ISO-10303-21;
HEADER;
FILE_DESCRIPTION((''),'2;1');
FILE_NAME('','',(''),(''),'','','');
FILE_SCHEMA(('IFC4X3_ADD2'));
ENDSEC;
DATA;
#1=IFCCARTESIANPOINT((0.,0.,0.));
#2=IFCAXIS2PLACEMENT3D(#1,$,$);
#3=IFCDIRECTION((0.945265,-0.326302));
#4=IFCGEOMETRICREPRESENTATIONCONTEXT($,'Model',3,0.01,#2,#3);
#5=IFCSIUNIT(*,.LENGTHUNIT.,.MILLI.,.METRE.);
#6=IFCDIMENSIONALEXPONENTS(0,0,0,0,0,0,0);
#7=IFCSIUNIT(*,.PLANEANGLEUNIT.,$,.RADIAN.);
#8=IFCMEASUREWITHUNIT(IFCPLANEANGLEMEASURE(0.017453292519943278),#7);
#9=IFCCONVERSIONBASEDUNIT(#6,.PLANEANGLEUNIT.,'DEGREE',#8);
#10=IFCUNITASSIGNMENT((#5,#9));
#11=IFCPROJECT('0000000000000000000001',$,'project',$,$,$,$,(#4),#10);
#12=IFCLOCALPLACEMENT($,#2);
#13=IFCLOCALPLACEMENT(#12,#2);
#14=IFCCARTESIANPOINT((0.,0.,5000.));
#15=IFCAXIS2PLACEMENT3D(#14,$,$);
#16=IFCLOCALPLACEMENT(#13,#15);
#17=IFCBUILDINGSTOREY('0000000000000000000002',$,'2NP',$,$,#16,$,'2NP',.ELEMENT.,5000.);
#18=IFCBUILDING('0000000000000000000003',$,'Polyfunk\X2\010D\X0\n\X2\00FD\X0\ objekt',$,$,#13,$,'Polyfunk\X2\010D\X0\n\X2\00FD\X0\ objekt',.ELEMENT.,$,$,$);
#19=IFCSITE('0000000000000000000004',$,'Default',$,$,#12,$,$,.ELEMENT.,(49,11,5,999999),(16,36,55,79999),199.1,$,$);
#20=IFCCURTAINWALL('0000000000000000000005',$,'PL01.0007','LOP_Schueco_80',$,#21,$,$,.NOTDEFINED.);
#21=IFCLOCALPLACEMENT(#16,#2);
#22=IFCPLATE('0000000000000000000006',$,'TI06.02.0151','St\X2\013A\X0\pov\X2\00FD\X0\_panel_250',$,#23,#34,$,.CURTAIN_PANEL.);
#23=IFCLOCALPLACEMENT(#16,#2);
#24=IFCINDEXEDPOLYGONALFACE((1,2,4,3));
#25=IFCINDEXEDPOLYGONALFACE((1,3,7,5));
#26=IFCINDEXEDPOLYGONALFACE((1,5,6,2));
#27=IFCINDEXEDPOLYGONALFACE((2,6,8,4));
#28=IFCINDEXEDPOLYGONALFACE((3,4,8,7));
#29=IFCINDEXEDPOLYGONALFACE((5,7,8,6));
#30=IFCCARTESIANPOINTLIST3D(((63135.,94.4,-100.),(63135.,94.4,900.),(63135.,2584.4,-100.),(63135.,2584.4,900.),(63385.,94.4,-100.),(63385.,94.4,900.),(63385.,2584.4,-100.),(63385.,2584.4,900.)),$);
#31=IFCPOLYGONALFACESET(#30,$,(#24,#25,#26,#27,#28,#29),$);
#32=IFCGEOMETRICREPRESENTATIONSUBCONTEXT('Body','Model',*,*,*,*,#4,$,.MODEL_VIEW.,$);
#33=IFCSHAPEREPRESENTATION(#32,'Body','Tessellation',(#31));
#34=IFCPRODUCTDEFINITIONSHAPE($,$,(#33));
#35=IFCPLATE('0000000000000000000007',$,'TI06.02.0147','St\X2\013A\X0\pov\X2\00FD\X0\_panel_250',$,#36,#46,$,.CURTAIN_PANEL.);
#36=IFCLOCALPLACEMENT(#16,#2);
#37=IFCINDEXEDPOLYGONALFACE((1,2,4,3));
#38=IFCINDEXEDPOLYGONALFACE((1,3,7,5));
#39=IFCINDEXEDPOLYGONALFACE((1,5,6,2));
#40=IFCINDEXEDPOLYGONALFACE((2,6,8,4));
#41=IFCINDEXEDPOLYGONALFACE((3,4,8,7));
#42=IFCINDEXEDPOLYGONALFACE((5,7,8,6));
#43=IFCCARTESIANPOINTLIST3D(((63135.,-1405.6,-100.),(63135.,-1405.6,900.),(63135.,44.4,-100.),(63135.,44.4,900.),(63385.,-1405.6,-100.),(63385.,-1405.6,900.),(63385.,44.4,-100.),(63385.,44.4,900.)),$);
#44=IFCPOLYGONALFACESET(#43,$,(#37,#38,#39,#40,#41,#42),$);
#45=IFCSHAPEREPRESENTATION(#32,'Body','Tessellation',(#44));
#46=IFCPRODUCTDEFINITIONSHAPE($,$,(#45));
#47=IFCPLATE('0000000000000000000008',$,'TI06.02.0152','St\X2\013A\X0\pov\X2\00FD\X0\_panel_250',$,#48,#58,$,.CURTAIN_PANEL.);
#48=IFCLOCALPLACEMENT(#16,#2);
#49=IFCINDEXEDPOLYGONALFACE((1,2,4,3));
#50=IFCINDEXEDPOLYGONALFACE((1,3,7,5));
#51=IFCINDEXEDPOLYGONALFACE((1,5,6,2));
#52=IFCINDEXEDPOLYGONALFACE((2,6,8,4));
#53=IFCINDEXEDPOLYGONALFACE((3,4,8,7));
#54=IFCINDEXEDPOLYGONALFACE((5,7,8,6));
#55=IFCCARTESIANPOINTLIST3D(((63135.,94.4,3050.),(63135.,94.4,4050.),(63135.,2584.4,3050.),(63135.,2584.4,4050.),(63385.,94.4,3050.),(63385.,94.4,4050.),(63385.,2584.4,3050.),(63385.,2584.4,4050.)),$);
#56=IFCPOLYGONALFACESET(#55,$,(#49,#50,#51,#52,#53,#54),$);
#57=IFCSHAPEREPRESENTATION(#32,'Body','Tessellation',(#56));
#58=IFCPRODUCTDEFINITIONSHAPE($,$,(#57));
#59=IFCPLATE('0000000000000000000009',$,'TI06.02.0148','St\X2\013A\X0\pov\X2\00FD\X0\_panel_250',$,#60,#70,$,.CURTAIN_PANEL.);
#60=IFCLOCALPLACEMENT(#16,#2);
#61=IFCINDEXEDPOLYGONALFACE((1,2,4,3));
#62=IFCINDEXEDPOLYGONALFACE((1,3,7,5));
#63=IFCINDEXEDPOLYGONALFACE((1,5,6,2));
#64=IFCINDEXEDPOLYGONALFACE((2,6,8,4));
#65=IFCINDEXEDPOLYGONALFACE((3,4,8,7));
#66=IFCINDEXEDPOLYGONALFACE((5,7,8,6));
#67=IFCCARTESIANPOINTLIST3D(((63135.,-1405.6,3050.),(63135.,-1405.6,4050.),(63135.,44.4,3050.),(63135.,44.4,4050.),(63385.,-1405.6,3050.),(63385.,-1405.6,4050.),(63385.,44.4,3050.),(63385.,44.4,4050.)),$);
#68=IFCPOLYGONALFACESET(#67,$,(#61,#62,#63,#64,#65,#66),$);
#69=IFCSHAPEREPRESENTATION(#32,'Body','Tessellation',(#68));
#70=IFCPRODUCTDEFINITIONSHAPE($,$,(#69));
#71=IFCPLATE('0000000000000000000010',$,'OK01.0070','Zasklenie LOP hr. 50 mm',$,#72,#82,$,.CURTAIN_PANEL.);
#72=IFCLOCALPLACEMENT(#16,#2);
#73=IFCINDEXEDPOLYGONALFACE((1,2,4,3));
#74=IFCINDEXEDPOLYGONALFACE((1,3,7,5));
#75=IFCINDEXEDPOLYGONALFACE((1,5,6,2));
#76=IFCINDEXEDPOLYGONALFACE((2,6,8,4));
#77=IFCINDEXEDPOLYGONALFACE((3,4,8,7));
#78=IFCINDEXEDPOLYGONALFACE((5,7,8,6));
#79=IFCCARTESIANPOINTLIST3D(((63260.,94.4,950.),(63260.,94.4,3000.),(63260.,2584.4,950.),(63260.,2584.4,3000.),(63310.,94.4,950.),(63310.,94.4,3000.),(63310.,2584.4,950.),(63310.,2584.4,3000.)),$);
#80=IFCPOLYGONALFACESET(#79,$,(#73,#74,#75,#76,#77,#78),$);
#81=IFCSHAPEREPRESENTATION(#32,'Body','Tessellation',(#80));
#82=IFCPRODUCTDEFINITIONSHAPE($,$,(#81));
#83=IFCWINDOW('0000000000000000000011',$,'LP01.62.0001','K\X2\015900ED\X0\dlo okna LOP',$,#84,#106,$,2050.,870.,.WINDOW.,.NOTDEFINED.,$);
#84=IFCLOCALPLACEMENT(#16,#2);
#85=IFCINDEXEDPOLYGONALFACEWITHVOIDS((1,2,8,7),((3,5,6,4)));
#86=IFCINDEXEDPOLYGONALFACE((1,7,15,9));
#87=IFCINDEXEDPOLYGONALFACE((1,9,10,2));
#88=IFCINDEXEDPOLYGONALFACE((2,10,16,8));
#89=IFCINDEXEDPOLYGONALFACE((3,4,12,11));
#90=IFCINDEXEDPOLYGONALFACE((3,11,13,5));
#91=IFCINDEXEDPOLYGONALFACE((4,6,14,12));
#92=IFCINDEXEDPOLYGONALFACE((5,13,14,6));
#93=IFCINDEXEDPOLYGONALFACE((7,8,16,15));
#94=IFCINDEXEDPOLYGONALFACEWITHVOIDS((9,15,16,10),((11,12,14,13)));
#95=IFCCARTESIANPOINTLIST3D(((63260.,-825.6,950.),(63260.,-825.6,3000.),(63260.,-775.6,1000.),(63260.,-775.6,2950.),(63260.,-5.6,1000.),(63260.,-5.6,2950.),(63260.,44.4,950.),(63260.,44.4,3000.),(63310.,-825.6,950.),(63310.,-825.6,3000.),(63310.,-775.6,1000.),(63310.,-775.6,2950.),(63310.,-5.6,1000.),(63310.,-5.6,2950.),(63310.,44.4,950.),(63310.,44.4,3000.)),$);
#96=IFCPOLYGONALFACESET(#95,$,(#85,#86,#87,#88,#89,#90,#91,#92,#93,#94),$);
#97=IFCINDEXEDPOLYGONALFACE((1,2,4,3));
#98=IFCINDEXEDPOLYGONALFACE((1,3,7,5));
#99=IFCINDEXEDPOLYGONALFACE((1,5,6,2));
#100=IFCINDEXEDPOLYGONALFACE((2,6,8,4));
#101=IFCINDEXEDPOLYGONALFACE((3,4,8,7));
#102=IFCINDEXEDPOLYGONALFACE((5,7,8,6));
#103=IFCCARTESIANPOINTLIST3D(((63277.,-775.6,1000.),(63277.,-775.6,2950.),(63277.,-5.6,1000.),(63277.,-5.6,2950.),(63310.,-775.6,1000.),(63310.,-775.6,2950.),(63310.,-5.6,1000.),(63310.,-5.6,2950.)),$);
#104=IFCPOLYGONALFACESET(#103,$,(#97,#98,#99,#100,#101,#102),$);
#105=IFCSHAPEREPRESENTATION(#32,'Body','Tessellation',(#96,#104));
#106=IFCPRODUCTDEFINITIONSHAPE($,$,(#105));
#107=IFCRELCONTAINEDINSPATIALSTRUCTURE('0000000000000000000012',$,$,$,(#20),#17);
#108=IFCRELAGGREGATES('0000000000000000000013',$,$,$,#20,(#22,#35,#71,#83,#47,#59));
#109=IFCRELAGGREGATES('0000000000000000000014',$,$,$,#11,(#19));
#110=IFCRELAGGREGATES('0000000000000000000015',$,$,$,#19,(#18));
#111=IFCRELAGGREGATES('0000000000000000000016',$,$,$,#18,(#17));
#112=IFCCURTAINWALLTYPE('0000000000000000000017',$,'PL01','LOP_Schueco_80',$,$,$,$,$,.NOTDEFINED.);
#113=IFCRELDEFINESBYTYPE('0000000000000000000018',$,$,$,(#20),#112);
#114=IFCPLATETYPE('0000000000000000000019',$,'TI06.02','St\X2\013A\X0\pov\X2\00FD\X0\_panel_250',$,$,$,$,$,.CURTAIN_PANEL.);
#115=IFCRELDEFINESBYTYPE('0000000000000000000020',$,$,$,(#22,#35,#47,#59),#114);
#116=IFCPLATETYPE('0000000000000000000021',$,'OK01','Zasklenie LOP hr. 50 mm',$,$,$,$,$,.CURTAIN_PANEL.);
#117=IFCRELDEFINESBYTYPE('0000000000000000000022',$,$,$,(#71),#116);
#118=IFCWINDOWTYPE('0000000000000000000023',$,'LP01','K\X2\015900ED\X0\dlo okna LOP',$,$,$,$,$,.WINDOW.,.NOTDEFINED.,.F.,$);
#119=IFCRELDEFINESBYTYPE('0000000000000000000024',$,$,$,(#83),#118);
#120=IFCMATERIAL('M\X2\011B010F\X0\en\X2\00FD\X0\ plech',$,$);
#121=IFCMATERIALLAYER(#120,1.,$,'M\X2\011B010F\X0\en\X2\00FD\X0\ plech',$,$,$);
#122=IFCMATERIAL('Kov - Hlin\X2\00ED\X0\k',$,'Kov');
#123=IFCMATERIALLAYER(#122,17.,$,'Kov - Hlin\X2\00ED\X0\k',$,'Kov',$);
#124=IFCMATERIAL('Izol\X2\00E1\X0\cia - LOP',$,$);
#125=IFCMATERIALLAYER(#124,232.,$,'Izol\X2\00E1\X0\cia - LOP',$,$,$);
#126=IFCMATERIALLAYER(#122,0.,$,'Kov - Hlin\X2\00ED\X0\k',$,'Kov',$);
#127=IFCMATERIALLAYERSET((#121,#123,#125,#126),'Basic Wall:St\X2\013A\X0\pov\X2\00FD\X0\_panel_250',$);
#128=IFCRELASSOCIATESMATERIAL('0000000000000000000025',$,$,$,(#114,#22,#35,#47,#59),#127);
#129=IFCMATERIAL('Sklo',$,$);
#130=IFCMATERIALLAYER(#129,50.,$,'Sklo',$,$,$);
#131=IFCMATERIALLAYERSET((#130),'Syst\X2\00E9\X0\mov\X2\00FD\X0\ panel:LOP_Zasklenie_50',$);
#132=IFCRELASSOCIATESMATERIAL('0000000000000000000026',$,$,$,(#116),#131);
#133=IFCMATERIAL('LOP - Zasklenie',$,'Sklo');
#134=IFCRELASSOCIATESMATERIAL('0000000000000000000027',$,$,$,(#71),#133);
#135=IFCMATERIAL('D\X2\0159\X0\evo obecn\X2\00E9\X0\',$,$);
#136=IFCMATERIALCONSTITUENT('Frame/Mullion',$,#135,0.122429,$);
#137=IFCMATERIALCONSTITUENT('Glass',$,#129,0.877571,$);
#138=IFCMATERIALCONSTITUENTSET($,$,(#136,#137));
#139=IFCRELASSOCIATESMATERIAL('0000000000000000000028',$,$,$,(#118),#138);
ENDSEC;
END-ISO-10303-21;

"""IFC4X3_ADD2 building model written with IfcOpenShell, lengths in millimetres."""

from ifc_helpers import new_model, entity, si_unit, converted_unit, direction, frame, frame_2d, origin, origin_2d_with_axis, place, context, subcontext, project, spatial, polyline, rectangle, outline, extrude, source, transform, mapped, material, layer, layer_set, layer_usage, constituent, constituent_set, type_object, type_shapes, element, aggregate, save


model = new_model("IFC4X3_ADD2")

# Units and contexts
model_context = context("Model", 3, precision=0.01, world=origin(), true_north=direction((0.945265, -0.326302)))
body_context = subcontext(model_context, "Body", "Model", "MODEL_VIEW")
ifc_project = project(units=[si_unit("LENGTHUNIT", "METRE", prefix="MILLI"), converted_unit("PLANEANGLEUNIT", "DEGREE", entity("IfcPlaneAngleMeasure", 0.017453292519943278), si_unit("PLANEANGLEUNIT", "RADIAN"), dimensions=[0, 0, 0, 0, 0, 0, 0])], contexts=[model_context])

# Site, building, storey
site_placement = place(None, origin())
site = spatial("IfcSite", under=ifc_project, at=site_placement, Name="Default", CompositionType="ELEMENT", RefLatitude=(49, 11, 5, 999999), RefLongitude=(16, 36, 55, 79999), RefElevation=199.1)
building_placement = place(site_placement, origin())
building = spatial("IfcBuilding", under=site, at=building_placement, Name="Polyfunkčný objekt", LongName="Polyfunkčný objekt", CompositionType="ELEMENT")
storey_placement = place(building_placement, frame((0.0, 0.0, 5000.0)))
storey = spatial("IfcBuildingStorey", under=building, at=storey_placement, Name="2NP", LongName="2NP", CompositionType="ELEMENT", Elevation=5000.0)

# Curtain wall, plates, window
curtain_wall_type = type_object("IfcCurtainWallType", Name="PL01", Description="LOP_Schueco_80", PredefinedType="NOTDEFINED")
curtain_wall_placement = place(storey_placement, frame((0.0, 0.0, -5000.0)))
curtain_wall = element("IfcCurtainWall", 1, at=curtain_wall_placement, inside=storey, type_object=curtain_wall_type, Name="PL01.0007", Description="LOP_Schueco_80", PredefinedType="NOTDEFINED")
ifc_material_1 = material(Name="Měďený plech")
ifc_layer_1 = layer(ifc_material_1, 1.0, Name="Měďený plech")
ifc_material_2 = material(Name="Kov - Hliník", Category="Kov")
ifc_layer_2 = layer(ifc_material_2, 17.0, Name="Kov - Hliník", Category="Kov")
ifc_material_3 = material(Name="Izolácia - LOP")
ifc_layer_3 = layer(ifc_material_3, 232.0, Name="Izolácia - LOP")
ifc_layer_4 = layer(ifc_material_2, 0.0, Name="Kov - Hliník", Category="Kov")
ifc_layer_set_1 = layer_set([ifc_layer_1, ifc_layer_2, ifc_layer_3, ifc_layer_4], Name="Basic Wall:Stĺpový_panel_250")
ifc_layer_usage_1 = layer_usage(ifc_layer_set_1, "AXIS2", "NEGATIVE", 125.0)
plate_type_1 = type_object("IfcPlateType", Name="TI06.02", Description="Stĺpový_panel_250", PredefinedType="CURTAIN_PANEL", material=ifc_layer_set_1)
plate_1_placement = place(storey_placement, frame((63260.0, 2584.4, -100.0), z_axis=(0.0, 0.0, 1.0), x_axis=(0.0, -1.0, 0.0)))
plate_1 = element("IfcPlate", 2, at=plate_1_placement, type_object=plate_type_1, material=ifc_layer_usage_1, Name="TI06.02.0151", Description="Stĺpový_panel_250", PredefinedType="CURTAIN_PANEL", context=body_context, shape_type="SweptSolid", body=[
    extrude(rectangle(XDim=250.0, YDim=2490.0, at=frame_2d((0.0, 0.0), x_axis=(1.0, 0.0))), frame((1245.0, 0.0, 0.0), z_axis=(0.0, 0.0, 1.0), x_axis=(0.0, 1.0, 0.0)), (0.0, 0.0, 1.0), 1000.0),
])
ifc_layer_usage_2 = layer_usage(ifc_layer_set_1, "AXIS2", "NEGATIVE", 125.0)
plate_2_placement = place(storey_placement, frame((63260.0, 44.4, -100.0), z_axis=(0.0, 0.0, 1.0), x_axis=(0.0, -1.0, 0.0)))
plate_2 = element("IfcPlate", 3, at=plate_2_placement, type_object=plate_type_1, material=ifc_layer_usage_2, Name="TI06.02.0147", Description="Stĺpový_panel_250", PredefinedType="CURTAIN_PANEL", context=body_context, shape_type="SweptSolid", body=[
    extrude(rectangle(XDim=250.0, YDim=1450.0, at=frame_2d((0.0, 0.0), x_axis=(1.0, 0.0))), frame((725.0, 0.0, 0.0), z_axis=(0.0, 0.0, 1.0), x_axis=(0.0, 1.0, 0.0)), (0.0, 0.0, 1.0), 1000.0),
])
ifc_layer_usage_3 = layer_usage(ifc_layer_set_1, "AXIS2", "NEGATIVE", 125.0)
plate_3_placement = place(storey_placement, frame((63260.0, 2584.4, 3050.0), z_axis=(0.0, 0.0, 1.0), x_axis=(0.0, -1.0, 0.0)))
plate_3 = element("IfcPlate", 4, at=plate_3_placement, type_object=plate_type_1, material=ifc_layer_usage_3, Name="TI06.02.0152", Description="Stĺpový_panel_250", PredefinedType="CURTAIN_PANEL", context=body_context, shape_type="SweptSolid", body=[
    extrude(rectangle(XDim=250.0, YDim=2490.0, at=frame_2d((0.0, 0.0), x_axis=(1.0, 0.0))), frame((1245.0, 0.0, 0.0), z_axis=(0.0, 0.0, 1.0), x_axis=(0.0, 1.0, 0.0)), (0.0, 0.0, 1.0), 1000.0),
])
ifc_layer_usage_4 = layer_usage(ifc_layer_set_1, "AXIS2", "NEGATIVE", 125.0)
plate_4_placement = place(storey_placement, frame((63260.0, 44.4, 3050.0), z_axis=(0.0, 0.0, 1.0), x_axis=(0.0, -1.0, 0.0)))
plate_4 = element("IfcPlate", 5, at=plate_4_placement, type_object=plate_type_1, material=ifc_layer_usage_4, Name="TI06.02.0148", Description="Stĺpový_panel_250", PredefinedType="CURTAIN_PANEL", context=body_context, shape_type="SweptSolid", body=[
    extrude(rectangle(XDim=250.0, YDim=1450.0, at=frame_2d((0.0, 0.0), x_axis=(1.0, 0.0))), frame((725.0, 0.0, 0.0), z_axis=(0.0, 0.0, 1.0), x_axis=(0.0, 1.0, 0.0)), (0.0, 0.0, 1.0), 1000.0),
])
ifc_material_4 = material(Name="LOP - Zasklenie", Category="Sklo")
ifc_material_5 = material(Name="Sklo")
ifc_layer_5 = layer(ifc_material_5, 50.0, Name="Sklo")
ifc_layer_set_2 = layer_set([ifc_layer_5], Name="Systémový panel:LOP_Zasklenie_50")
plate_type_2 = type_object("IfcPlateType", Name="OK01", Description="Zasklenie LOP hr. 50 mm", PredefinedType="CURTAIN_PANEL", material=ifc_layer_set_2)
shared_shape_1 = source(origin(), body_context, "Body", "SweptSolid", [
    extrude(rectangle(XDim=50.0, YDim=2490.0, at=origin_2d_with_axis()), frame((0.0, 25.0, 0.0), z_axis=(0.0, 0.0, 1.0), x_axis=(0.0, 1.0, 0.0)), (0.0, 0.0, 1.0), 2050.0),
])
type_shapes(plate_type_2, [shared_shape_1])
plate_5_placement = place(curtain_wall_placement, frame((63260.0, 1339.4, 5950.0), z_axis=(0.0, 0.0, 1.0), x_axis=(0.0, -1.0, 0.0)))
plate_5 = element("IfcPlate", 6, at=plate_5_placement, type_object=plate_type_2, material=ifc_material_4, Name="OK01.0070", Description="Zasklenie LOP hr. 50 mm", PredefinedType="CURTAIN_PANEL", context=body_context, shape_type="MappedRepresentation", body=[
    mapped(shared_shape_1, transform((0.0, 0.0, 0.0), scale=1.0)),
])
ifc_material_6 = material(Name="Dřevo obecné")
ifc_constituent_1 = constituent(ifc_material_6, Name="Frame/Mullion", fraction=0.122429)
ifc_constituent_2 = constituent(ifc_material_5, Name="Glass", fraction=0.877571)
ifc_constituent_set = constituent_set(constituents=[ifc_constituent_1, ifc_constituent_2])
window_type = type_object("IfcWindowType", Name="LP01", Description="Křídlo okna LOP", ParameterTakesPrecedence=False, PartitioningType="NOTDEFINED", PredefinedType="WINDOW", material=ifc_constituent_set)
shared_shape_2 = source(origin(), body_context, "Body", "SweptSolid", [
    extrude(outline(polyline([(-1025.0, -435.0), (1025.0, -435.0), (1025.0, 435.0), (-1025.0, 435.0), (-1025.0, -435.0)]), holes=[polyline([(-975.0, -385.0), (-975.0, 385.0), (975.0, 385.0), (975.0, -385.0), (-975.0, -385.0)])]), frame((0.0, 0.0, 1025.0), z_axis=(0.0, 1.0, 0.0), x_axis=(0.0, 0.0, -1.0)), (0.0, 0.0, 1.0), 50.0),
    extrude(rectangle(XDim=33.0, YDim=770.0, at=origin_2d_with_axis()), frame((0.0, 33.5, 50.0), z_axis=(0.0, 0.0, 1.0), x_axis=(0.0, -1.0, 0.0)), (0.0, 0.0, 1.0), 1950.0),
])
type_shapes(window_type, [shared_shape_2])
window_placement = place(curtain_wall_placement, frame((63260.0, -390.6, 5950.0), z_axis=(0.0, 0.0, 1.0), x_axis=(0.0, -1.0, 0.0)))
window = element("IfcWindow", 7, at=window_placement, type_object=window_type, Name="LP01.62.0001", Description="Křídlo okna LOP", OverallHeight=2050.0, OverallWidth=870.0, PartitioningType="NOTDEFINED", PredefinedType="WINDOW", context=body_context, shape_type="MappedRepresentation", body=[
    mapped(shared_shape_2, transform((0.0, 0.0, 0.0), scale=1.0)),
])
aggregate(curtain_wall, [plate_1, plate_2, plate_5, window, plate_3, plate_4])

save(model, "model.ifc")
